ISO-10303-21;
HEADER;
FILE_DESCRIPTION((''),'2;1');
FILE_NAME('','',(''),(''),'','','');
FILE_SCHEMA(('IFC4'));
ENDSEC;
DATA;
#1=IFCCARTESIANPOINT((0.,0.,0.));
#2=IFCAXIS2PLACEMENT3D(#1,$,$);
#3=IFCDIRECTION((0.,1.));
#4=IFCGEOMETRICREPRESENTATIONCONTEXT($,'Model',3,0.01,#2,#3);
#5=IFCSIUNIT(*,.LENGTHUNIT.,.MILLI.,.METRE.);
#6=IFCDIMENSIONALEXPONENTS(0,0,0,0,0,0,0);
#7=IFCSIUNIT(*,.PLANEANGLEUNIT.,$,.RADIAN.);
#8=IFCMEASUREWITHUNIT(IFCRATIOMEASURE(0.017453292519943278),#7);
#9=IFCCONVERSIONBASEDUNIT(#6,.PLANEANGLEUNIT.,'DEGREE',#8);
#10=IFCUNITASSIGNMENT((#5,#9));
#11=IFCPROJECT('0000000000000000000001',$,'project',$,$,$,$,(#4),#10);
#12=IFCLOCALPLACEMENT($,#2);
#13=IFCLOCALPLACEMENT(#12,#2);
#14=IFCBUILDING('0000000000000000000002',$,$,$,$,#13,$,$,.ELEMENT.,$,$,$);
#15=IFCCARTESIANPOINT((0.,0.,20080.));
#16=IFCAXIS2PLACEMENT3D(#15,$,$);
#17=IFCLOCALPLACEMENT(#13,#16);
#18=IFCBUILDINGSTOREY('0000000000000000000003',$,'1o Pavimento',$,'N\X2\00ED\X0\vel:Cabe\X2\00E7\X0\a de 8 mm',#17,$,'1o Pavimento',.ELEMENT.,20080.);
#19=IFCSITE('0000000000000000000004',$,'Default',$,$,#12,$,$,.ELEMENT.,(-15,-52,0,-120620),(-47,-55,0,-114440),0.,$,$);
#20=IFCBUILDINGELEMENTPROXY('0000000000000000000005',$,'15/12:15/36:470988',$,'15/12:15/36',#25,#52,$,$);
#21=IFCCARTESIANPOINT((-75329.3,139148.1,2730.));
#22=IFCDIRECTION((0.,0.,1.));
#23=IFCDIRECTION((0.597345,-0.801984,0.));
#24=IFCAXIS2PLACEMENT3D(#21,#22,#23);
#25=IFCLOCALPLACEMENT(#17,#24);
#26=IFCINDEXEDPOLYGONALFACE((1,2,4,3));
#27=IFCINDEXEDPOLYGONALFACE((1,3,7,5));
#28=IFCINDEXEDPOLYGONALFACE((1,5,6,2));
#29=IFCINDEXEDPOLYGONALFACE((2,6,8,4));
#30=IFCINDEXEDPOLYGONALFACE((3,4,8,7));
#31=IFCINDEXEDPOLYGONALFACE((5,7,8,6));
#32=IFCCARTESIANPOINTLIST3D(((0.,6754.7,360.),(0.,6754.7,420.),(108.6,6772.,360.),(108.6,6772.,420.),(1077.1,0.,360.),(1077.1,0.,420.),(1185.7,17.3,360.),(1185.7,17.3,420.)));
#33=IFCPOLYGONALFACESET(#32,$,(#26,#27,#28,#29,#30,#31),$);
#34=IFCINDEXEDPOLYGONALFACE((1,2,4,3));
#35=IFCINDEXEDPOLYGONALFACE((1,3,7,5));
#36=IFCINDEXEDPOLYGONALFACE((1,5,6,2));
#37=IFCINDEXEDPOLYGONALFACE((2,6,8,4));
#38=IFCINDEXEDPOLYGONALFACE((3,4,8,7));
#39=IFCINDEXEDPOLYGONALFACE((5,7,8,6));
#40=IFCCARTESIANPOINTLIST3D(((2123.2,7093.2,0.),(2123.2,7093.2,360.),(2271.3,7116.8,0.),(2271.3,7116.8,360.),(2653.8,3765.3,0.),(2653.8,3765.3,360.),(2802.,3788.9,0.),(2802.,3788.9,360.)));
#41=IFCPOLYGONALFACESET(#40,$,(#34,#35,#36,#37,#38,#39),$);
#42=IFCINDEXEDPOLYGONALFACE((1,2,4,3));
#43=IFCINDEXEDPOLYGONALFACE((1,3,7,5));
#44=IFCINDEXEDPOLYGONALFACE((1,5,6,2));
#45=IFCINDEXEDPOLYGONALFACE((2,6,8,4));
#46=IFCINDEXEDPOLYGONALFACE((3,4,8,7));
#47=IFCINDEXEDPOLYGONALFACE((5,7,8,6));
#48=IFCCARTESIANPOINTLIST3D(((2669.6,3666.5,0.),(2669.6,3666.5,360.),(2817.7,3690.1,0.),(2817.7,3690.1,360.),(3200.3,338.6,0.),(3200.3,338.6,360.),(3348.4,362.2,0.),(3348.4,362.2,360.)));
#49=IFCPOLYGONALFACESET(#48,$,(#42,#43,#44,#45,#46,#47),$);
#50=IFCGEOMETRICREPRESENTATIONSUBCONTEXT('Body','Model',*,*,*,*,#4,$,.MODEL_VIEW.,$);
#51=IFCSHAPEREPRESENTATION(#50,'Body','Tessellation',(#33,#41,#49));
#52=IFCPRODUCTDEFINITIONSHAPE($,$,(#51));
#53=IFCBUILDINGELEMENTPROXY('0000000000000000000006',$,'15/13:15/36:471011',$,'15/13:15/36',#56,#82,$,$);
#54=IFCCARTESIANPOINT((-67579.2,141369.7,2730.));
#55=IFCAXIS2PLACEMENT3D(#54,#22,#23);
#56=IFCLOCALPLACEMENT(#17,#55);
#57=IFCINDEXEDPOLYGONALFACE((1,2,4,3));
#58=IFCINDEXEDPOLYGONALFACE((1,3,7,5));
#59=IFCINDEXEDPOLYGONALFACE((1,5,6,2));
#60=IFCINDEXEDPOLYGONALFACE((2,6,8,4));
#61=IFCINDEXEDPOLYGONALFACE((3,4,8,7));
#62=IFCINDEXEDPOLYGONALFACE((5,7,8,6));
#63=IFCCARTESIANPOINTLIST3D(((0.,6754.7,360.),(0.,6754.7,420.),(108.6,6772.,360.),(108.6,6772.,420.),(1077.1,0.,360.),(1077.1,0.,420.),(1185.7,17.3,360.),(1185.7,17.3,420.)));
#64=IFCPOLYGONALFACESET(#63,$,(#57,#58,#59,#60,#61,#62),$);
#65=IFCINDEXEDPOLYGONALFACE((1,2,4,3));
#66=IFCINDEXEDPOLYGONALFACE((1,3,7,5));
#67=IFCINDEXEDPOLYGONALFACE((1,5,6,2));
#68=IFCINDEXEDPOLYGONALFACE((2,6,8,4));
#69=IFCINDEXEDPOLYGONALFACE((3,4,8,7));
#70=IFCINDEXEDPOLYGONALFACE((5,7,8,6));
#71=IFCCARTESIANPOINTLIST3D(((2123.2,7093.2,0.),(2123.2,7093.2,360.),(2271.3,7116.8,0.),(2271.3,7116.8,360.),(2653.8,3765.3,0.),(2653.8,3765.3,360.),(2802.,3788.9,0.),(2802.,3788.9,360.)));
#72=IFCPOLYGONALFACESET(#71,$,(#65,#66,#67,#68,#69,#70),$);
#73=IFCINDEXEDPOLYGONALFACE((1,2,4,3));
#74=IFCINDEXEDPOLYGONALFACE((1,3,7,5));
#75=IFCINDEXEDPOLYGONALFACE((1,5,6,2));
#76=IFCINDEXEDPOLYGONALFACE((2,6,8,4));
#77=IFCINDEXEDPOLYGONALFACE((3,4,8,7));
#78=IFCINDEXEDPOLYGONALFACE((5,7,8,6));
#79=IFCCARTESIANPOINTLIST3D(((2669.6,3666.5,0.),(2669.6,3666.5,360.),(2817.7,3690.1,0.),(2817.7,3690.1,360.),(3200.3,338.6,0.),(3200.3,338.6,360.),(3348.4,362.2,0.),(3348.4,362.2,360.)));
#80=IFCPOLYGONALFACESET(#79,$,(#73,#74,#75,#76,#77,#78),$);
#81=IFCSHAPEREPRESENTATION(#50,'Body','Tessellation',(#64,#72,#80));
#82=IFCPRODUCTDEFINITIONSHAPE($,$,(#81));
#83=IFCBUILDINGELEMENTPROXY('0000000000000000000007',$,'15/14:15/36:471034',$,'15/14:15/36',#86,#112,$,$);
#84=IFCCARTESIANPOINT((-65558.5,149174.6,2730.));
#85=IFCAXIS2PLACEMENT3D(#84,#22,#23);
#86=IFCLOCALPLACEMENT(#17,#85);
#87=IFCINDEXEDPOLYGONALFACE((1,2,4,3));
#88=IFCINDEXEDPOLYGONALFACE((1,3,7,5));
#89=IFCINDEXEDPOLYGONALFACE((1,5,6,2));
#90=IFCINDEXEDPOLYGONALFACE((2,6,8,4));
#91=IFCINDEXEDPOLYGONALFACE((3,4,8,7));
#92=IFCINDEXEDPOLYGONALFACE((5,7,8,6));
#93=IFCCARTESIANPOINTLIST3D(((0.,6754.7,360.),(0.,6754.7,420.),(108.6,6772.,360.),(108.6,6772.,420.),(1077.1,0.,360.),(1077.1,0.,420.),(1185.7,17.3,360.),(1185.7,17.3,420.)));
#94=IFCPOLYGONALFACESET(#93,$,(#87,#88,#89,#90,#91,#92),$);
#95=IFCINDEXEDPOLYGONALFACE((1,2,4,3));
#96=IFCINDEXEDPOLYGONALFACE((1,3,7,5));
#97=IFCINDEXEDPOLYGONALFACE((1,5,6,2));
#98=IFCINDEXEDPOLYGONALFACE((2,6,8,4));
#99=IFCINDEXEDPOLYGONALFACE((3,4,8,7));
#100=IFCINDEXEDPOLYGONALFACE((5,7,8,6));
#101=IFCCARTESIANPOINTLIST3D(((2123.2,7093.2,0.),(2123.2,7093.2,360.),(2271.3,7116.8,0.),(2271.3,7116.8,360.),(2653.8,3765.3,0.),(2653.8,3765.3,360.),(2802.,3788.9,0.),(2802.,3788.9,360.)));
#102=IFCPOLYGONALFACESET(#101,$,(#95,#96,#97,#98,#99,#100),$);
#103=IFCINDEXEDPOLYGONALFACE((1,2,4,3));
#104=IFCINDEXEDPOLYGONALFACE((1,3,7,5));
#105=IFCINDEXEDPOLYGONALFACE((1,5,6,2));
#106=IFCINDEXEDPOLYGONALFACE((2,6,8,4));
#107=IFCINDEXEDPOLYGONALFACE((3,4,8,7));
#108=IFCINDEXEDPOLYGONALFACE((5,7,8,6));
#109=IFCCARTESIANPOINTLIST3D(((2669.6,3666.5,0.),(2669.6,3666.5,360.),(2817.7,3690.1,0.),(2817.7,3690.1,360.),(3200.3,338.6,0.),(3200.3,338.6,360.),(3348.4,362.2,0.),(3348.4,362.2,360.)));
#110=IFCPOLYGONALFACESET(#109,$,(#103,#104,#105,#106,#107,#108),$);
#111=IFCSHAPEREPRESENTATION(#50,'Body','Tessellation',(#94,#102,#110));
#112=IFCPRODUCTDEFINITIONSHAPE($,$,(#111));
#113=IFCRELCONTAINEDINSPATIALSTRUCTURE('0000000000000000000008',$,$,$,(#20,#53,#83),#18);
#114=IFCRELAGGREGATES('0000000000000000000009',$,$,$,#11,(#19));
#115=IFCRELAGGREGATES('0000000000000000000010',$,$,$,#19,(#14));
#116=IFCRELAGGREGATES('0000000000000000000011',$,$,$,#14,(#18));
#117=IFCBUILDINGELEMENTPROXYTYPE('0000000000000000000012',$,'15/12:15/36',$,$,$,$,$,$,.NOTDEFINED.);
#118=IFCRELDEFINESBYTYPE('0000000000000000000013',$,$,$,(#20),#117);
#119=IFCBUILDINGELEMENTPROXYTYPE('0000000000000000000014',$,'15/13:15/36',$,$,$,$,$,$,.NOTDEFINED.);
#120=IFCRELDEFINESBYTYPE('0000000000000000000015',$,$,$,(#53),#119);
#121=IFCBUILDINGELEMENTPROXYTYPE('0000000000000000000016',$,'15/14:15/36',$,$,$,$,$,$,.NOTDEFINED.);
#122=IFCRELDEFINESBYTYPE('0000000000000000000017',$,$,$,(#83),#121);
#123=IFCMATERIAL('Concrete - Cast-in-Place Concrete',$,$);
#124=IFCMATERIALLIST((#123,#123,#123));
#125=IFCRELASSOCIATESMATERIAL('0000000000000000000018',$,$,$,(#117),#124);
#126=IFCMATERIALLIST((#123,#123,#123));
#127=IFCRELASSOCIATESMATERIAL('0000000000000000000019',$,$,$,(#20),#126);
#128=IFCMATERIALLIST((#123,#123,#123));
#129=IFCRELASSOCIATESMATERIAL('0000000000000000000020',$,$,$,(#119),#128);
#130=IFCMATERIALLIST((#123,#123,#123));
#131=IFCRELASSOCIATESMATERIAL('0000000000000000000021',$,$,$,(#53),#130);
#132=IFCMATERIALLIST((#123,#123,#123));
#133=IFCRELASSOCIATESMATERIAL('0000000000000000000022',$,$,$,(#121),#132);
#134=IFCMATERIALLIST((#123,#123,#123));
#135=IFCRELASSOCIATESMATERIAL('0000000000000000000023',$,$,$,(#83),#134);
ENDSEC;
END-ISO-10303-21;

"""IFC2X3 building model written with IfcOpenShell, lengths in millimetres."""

from ifc_helpers import new_model, entity, si_unit, converted_unit, direction, frame, frame_2d, origin, place, context, subcontext, project, spatial, rectangle, extrude, source, transform, mapped, material, material_list, type_object, type_shapes, element, save


model = new_model("IFC2X3")

# Units and contexts
model_context = context("Model", 3, precision=0.01, world=origin(), true_north=direction((0.0, 1.0)))
body_context = subcontext(model_context, "Body", "Model", "MODEL_VIEW")
ifc_project = project(units=[si_unit("LENGTHUNIT", "METRE", prefix="MILLI"), converted_unit("PLANEANGLEUNIT", "DEGREE", entity("IfcRatioMeasure", 0.017453292519943278), si_unit("PLANEANGLEUNIT", "RADIAN"), dimensions=[0, 0, 0, 0, 0, 0, 0])], contexts=[model_context])

# Site, building, storey
site_placement = place(None, origin())
site = spatial("IfcSite", under=ifc_project, at=site_placement, Name="Default", CompositionType="ELEMENT", RefLatitude=(-15, -52, 0, -120620), RefLongitude=(-47, -55, 0, -114440), RefElevation=0.0)
building_placement = place(site_placement, origin())
building = spatial("IfcBuilding", under=site, at=building_placement, CompositionType="ELEMENT")
storey_placement = place(building_placement, frame((0.0, 0.0, 20080.0)))
storey = spatial("IfcBuildingStorey", under=building, at=storey_placement, Name="1o Pavimento", ObjectType="Nível:Cabeça de 8 mm", LongName="1o Pavimento", CompositionType="ELEMENT", Elevation=20080.0)

# Building element proxies
ifc_material_1 = material(Name="Concrete - Cast-in-Place Concrete")
ifc_material_list_1 = material_list([ifc_material_1, ifc_material_1, ifc_material_1])
ifc_material_list_2 = material_list([ifc_material_1, ifc_material_1, ifc_material_1])
building_element_proxy_type_1 = type_object("IfcBuildingElementProxyType", Name="15/12:15/36", PredefinedType="NOTDEFINED", material=ifc_material_list_2)
shared_shape_1 = source(origin(), body_context, "Body", "SweptSolid", [
    extrude(rectangle(XDim=110.0, YDim=6840.0, at=frame_2d((0.0, 0.0), x_axis=(1.0, 0.0))), frame((592.9, 3386.0, 360.0), z_axis=(0.0, 0.0, 1.0), x_axis=(-0.987524, -0.157469, 0.0)), (0.0, 0.0, 1.0), 60.0),
    extrude(rectangle(XDim=3370.0, YDim=150.0, at=frame_2d((0.0, 0.0), x_axis=(1.0, 0.0))), frame((2462.6, 5441.1, 0.0), z_axis=(0.0, 0.0, 1.0), x_axis=(0.157469, -0.987524, 0.0)), (0.0, 0.0, 1.0), 360.0),
    extrude(rectangle(XDim=3370.0, YDim=150.0, at=frame_2d((0.0, 0.0), x_axis=(1.0, 0.0))), frame((3009.0, 2014.3, 0.0), z_axis=(0.0, 0.0, 1.0), x_axis=(0.157469, -0.987524, 0.0)), (0.0, 0.0, 1.0), 360.0),
])
type_shapes(building_element_proxy_type_1, [shared_shape_1])
proxy_1_placement = place(storey_placement, frame((-75329.3, 139148.1, 2730.0), z_axis=(0.0, 0.0, 1.0), x_axis=(0.597345, -0.801984, 0.0)))
element("IfcBuildingElementProxy", 1, at=proxy_1_placement, inside=storey, type_object=building_element_proxy_type_1, material=ifc_material_list_1, Name="15/12:15/36:470988", ObjectType="15/12:15/36", context=body_context, shape_type="MappedRepresentation", body=[
    mapped(shared_shape_1, transform((0.0, 0.0, 0.0), scale=1.0)),
])
ifc_material_list_3 = material_list([ifc_material_1, ifc_material_1, ifc_material_1])
ifc_material_list_4 = material_list([ifc_material_1, ifc_material_1, ifc_material_1])
building_element_proxy_type_2 = type_object("IfcBuildingElementProxyType", Name="15/13:15/36", PredefinedType="NOTDEFINED", material=ifc_material_list_4)
shared_shape_2 = source(origin(), body_context, "Body", "SweptSolid", [
    extrude(rectangle(XDim=110.0, YDim=6840.0, at=frame_2d((0.0, 0.0), x_axis=(1.0, 0.0))), frame((592.9, 3386.0, 360.0), z_axis=(0.0, 0.0, 1.0), x_axis=(-0.987524, -0.157469, 0.0)), (0.0, 0.0, 1.0), 60.0),
    extrude(rectangle(XDim=3370.0, YDim=150.0, at=frame_2d((0.0, 0.0), x_axis=(1.0, 0.0))), frame((2462.6, 5441.1, 0.0), z_axis=(0.0, 0.0, 1.0), x_axis=(0.157469, -0.987524, 0.0)), (0.0, 0.0, 1.0), 360.0),
    extrude(rectangle(XDim=3370.0, YDim=150.0, at=frame_2d((0.0, 0.0), x_axis=(1.0, 0.0))), frame((3009.0, 2014.3, 0.0), z_axis=(0.0, 0.0, 1.0), x_axis=(0.157469, -0.987524, 0.0)), (0.0, 0.0, 1.0), 360.0),
])
type_shapes(building_element_proxy_type_2, [shared_shape_2])
proxy_2_placement = place(storey_placement, frame((-67579.2, 141369.7, 2730.0), z_axis=(0.0, 0.0, 1.0), x_axis=(0.597345, -0.801984, 0.0)))
element("IfcBuildingElementProxy", 2, at=proxy_2_placement, inside=storey, type_object=building_element_proxy_type_2, material=ifc_material_list_3, Name="15/13:15/36:471011", ObjectType="15/13:15/36", context=body_context, shape_type="MappedRepresentation", body=[
    mapped(shared_shape_2, transform((0.0, 0.0, 0.0), scale=1.0)),
])
ifc_material_list_5 = material_list([ifc_material_1, ifc_material_1, ifc_material_1])
ifc_material_list_6 = material_list([ifc_material_1, ifc_material_1, ifc_material_1])
building_element_proxy_type_3 = type_object("IfcBuildingElementProxyType", Name="15/14:15/36", PredefinedType="NOTDEFINED", material=ifc_material_list_6)
shared_shape_3 = source(origin(), body_context, "Body", "SweptSolid", [
    extrude(rectangle(XDim=110.0, YDim=6840.0, at=frame_2d((0.0, 0.0), x_axis=(1.0, 0.0))), frame((592.9, 3386.0, 360.0), z_axis=(0.0, 0.0, 1.0), x_axis=(-0.987524, -0.157469, 0.0)), (0.0, 0.0, 1.0), 60.0),
    extrude(rectangle(XDim=3370.0, YDim=150.0, at=frame_2d((0.0, 0.0), x_axis=(1.0, 0.0))), frame((2462.6, 5441.1, 0.0), z_axis=(0.0, 0.0, 1.0), x_axis=(0.157469, -0.987524, 0.0)), (0.0, 0.0, 1.0), 360.0),
    extrude(rectangle(XDim=3370.0, YDim=150.0, at=frame_2d((0.0, 0.0), x_axis=(1.0, 0.0))), frame((3009.0, 2014.3, 0.0), z_axis=(0.0, 0.0, 1.0), x_axis=(0.157469, -0.987524, 0.0)), (0.0, 0.0, 1.0), 360.0),
])
type_shapes(building_element_proxy_type_3, [shared_shape_3])
proxy_3_placement = place(storey_placement, frame((-65558.5, 149174.6, 2730.0), z_axis=(0.0, 0.0, 1.0), x_axis=(0.597345, -0.801984, 0.0)))
element("IfcBuildingElementProxy", 3, at=proxy_3_placement, inside=storey, type_object=building_element_proxy_type_3, material=ifc_material_list_5, Name="15/14:15/36:471034", ObjectType="15/14:15/36", context=body_context, shape_type="MappedRepresentation", body=[
    mapped(shared_shape_3, transform((0.0, 0.0, 0.0), scale=1.0)),
])

save(model, "model.ifc")
